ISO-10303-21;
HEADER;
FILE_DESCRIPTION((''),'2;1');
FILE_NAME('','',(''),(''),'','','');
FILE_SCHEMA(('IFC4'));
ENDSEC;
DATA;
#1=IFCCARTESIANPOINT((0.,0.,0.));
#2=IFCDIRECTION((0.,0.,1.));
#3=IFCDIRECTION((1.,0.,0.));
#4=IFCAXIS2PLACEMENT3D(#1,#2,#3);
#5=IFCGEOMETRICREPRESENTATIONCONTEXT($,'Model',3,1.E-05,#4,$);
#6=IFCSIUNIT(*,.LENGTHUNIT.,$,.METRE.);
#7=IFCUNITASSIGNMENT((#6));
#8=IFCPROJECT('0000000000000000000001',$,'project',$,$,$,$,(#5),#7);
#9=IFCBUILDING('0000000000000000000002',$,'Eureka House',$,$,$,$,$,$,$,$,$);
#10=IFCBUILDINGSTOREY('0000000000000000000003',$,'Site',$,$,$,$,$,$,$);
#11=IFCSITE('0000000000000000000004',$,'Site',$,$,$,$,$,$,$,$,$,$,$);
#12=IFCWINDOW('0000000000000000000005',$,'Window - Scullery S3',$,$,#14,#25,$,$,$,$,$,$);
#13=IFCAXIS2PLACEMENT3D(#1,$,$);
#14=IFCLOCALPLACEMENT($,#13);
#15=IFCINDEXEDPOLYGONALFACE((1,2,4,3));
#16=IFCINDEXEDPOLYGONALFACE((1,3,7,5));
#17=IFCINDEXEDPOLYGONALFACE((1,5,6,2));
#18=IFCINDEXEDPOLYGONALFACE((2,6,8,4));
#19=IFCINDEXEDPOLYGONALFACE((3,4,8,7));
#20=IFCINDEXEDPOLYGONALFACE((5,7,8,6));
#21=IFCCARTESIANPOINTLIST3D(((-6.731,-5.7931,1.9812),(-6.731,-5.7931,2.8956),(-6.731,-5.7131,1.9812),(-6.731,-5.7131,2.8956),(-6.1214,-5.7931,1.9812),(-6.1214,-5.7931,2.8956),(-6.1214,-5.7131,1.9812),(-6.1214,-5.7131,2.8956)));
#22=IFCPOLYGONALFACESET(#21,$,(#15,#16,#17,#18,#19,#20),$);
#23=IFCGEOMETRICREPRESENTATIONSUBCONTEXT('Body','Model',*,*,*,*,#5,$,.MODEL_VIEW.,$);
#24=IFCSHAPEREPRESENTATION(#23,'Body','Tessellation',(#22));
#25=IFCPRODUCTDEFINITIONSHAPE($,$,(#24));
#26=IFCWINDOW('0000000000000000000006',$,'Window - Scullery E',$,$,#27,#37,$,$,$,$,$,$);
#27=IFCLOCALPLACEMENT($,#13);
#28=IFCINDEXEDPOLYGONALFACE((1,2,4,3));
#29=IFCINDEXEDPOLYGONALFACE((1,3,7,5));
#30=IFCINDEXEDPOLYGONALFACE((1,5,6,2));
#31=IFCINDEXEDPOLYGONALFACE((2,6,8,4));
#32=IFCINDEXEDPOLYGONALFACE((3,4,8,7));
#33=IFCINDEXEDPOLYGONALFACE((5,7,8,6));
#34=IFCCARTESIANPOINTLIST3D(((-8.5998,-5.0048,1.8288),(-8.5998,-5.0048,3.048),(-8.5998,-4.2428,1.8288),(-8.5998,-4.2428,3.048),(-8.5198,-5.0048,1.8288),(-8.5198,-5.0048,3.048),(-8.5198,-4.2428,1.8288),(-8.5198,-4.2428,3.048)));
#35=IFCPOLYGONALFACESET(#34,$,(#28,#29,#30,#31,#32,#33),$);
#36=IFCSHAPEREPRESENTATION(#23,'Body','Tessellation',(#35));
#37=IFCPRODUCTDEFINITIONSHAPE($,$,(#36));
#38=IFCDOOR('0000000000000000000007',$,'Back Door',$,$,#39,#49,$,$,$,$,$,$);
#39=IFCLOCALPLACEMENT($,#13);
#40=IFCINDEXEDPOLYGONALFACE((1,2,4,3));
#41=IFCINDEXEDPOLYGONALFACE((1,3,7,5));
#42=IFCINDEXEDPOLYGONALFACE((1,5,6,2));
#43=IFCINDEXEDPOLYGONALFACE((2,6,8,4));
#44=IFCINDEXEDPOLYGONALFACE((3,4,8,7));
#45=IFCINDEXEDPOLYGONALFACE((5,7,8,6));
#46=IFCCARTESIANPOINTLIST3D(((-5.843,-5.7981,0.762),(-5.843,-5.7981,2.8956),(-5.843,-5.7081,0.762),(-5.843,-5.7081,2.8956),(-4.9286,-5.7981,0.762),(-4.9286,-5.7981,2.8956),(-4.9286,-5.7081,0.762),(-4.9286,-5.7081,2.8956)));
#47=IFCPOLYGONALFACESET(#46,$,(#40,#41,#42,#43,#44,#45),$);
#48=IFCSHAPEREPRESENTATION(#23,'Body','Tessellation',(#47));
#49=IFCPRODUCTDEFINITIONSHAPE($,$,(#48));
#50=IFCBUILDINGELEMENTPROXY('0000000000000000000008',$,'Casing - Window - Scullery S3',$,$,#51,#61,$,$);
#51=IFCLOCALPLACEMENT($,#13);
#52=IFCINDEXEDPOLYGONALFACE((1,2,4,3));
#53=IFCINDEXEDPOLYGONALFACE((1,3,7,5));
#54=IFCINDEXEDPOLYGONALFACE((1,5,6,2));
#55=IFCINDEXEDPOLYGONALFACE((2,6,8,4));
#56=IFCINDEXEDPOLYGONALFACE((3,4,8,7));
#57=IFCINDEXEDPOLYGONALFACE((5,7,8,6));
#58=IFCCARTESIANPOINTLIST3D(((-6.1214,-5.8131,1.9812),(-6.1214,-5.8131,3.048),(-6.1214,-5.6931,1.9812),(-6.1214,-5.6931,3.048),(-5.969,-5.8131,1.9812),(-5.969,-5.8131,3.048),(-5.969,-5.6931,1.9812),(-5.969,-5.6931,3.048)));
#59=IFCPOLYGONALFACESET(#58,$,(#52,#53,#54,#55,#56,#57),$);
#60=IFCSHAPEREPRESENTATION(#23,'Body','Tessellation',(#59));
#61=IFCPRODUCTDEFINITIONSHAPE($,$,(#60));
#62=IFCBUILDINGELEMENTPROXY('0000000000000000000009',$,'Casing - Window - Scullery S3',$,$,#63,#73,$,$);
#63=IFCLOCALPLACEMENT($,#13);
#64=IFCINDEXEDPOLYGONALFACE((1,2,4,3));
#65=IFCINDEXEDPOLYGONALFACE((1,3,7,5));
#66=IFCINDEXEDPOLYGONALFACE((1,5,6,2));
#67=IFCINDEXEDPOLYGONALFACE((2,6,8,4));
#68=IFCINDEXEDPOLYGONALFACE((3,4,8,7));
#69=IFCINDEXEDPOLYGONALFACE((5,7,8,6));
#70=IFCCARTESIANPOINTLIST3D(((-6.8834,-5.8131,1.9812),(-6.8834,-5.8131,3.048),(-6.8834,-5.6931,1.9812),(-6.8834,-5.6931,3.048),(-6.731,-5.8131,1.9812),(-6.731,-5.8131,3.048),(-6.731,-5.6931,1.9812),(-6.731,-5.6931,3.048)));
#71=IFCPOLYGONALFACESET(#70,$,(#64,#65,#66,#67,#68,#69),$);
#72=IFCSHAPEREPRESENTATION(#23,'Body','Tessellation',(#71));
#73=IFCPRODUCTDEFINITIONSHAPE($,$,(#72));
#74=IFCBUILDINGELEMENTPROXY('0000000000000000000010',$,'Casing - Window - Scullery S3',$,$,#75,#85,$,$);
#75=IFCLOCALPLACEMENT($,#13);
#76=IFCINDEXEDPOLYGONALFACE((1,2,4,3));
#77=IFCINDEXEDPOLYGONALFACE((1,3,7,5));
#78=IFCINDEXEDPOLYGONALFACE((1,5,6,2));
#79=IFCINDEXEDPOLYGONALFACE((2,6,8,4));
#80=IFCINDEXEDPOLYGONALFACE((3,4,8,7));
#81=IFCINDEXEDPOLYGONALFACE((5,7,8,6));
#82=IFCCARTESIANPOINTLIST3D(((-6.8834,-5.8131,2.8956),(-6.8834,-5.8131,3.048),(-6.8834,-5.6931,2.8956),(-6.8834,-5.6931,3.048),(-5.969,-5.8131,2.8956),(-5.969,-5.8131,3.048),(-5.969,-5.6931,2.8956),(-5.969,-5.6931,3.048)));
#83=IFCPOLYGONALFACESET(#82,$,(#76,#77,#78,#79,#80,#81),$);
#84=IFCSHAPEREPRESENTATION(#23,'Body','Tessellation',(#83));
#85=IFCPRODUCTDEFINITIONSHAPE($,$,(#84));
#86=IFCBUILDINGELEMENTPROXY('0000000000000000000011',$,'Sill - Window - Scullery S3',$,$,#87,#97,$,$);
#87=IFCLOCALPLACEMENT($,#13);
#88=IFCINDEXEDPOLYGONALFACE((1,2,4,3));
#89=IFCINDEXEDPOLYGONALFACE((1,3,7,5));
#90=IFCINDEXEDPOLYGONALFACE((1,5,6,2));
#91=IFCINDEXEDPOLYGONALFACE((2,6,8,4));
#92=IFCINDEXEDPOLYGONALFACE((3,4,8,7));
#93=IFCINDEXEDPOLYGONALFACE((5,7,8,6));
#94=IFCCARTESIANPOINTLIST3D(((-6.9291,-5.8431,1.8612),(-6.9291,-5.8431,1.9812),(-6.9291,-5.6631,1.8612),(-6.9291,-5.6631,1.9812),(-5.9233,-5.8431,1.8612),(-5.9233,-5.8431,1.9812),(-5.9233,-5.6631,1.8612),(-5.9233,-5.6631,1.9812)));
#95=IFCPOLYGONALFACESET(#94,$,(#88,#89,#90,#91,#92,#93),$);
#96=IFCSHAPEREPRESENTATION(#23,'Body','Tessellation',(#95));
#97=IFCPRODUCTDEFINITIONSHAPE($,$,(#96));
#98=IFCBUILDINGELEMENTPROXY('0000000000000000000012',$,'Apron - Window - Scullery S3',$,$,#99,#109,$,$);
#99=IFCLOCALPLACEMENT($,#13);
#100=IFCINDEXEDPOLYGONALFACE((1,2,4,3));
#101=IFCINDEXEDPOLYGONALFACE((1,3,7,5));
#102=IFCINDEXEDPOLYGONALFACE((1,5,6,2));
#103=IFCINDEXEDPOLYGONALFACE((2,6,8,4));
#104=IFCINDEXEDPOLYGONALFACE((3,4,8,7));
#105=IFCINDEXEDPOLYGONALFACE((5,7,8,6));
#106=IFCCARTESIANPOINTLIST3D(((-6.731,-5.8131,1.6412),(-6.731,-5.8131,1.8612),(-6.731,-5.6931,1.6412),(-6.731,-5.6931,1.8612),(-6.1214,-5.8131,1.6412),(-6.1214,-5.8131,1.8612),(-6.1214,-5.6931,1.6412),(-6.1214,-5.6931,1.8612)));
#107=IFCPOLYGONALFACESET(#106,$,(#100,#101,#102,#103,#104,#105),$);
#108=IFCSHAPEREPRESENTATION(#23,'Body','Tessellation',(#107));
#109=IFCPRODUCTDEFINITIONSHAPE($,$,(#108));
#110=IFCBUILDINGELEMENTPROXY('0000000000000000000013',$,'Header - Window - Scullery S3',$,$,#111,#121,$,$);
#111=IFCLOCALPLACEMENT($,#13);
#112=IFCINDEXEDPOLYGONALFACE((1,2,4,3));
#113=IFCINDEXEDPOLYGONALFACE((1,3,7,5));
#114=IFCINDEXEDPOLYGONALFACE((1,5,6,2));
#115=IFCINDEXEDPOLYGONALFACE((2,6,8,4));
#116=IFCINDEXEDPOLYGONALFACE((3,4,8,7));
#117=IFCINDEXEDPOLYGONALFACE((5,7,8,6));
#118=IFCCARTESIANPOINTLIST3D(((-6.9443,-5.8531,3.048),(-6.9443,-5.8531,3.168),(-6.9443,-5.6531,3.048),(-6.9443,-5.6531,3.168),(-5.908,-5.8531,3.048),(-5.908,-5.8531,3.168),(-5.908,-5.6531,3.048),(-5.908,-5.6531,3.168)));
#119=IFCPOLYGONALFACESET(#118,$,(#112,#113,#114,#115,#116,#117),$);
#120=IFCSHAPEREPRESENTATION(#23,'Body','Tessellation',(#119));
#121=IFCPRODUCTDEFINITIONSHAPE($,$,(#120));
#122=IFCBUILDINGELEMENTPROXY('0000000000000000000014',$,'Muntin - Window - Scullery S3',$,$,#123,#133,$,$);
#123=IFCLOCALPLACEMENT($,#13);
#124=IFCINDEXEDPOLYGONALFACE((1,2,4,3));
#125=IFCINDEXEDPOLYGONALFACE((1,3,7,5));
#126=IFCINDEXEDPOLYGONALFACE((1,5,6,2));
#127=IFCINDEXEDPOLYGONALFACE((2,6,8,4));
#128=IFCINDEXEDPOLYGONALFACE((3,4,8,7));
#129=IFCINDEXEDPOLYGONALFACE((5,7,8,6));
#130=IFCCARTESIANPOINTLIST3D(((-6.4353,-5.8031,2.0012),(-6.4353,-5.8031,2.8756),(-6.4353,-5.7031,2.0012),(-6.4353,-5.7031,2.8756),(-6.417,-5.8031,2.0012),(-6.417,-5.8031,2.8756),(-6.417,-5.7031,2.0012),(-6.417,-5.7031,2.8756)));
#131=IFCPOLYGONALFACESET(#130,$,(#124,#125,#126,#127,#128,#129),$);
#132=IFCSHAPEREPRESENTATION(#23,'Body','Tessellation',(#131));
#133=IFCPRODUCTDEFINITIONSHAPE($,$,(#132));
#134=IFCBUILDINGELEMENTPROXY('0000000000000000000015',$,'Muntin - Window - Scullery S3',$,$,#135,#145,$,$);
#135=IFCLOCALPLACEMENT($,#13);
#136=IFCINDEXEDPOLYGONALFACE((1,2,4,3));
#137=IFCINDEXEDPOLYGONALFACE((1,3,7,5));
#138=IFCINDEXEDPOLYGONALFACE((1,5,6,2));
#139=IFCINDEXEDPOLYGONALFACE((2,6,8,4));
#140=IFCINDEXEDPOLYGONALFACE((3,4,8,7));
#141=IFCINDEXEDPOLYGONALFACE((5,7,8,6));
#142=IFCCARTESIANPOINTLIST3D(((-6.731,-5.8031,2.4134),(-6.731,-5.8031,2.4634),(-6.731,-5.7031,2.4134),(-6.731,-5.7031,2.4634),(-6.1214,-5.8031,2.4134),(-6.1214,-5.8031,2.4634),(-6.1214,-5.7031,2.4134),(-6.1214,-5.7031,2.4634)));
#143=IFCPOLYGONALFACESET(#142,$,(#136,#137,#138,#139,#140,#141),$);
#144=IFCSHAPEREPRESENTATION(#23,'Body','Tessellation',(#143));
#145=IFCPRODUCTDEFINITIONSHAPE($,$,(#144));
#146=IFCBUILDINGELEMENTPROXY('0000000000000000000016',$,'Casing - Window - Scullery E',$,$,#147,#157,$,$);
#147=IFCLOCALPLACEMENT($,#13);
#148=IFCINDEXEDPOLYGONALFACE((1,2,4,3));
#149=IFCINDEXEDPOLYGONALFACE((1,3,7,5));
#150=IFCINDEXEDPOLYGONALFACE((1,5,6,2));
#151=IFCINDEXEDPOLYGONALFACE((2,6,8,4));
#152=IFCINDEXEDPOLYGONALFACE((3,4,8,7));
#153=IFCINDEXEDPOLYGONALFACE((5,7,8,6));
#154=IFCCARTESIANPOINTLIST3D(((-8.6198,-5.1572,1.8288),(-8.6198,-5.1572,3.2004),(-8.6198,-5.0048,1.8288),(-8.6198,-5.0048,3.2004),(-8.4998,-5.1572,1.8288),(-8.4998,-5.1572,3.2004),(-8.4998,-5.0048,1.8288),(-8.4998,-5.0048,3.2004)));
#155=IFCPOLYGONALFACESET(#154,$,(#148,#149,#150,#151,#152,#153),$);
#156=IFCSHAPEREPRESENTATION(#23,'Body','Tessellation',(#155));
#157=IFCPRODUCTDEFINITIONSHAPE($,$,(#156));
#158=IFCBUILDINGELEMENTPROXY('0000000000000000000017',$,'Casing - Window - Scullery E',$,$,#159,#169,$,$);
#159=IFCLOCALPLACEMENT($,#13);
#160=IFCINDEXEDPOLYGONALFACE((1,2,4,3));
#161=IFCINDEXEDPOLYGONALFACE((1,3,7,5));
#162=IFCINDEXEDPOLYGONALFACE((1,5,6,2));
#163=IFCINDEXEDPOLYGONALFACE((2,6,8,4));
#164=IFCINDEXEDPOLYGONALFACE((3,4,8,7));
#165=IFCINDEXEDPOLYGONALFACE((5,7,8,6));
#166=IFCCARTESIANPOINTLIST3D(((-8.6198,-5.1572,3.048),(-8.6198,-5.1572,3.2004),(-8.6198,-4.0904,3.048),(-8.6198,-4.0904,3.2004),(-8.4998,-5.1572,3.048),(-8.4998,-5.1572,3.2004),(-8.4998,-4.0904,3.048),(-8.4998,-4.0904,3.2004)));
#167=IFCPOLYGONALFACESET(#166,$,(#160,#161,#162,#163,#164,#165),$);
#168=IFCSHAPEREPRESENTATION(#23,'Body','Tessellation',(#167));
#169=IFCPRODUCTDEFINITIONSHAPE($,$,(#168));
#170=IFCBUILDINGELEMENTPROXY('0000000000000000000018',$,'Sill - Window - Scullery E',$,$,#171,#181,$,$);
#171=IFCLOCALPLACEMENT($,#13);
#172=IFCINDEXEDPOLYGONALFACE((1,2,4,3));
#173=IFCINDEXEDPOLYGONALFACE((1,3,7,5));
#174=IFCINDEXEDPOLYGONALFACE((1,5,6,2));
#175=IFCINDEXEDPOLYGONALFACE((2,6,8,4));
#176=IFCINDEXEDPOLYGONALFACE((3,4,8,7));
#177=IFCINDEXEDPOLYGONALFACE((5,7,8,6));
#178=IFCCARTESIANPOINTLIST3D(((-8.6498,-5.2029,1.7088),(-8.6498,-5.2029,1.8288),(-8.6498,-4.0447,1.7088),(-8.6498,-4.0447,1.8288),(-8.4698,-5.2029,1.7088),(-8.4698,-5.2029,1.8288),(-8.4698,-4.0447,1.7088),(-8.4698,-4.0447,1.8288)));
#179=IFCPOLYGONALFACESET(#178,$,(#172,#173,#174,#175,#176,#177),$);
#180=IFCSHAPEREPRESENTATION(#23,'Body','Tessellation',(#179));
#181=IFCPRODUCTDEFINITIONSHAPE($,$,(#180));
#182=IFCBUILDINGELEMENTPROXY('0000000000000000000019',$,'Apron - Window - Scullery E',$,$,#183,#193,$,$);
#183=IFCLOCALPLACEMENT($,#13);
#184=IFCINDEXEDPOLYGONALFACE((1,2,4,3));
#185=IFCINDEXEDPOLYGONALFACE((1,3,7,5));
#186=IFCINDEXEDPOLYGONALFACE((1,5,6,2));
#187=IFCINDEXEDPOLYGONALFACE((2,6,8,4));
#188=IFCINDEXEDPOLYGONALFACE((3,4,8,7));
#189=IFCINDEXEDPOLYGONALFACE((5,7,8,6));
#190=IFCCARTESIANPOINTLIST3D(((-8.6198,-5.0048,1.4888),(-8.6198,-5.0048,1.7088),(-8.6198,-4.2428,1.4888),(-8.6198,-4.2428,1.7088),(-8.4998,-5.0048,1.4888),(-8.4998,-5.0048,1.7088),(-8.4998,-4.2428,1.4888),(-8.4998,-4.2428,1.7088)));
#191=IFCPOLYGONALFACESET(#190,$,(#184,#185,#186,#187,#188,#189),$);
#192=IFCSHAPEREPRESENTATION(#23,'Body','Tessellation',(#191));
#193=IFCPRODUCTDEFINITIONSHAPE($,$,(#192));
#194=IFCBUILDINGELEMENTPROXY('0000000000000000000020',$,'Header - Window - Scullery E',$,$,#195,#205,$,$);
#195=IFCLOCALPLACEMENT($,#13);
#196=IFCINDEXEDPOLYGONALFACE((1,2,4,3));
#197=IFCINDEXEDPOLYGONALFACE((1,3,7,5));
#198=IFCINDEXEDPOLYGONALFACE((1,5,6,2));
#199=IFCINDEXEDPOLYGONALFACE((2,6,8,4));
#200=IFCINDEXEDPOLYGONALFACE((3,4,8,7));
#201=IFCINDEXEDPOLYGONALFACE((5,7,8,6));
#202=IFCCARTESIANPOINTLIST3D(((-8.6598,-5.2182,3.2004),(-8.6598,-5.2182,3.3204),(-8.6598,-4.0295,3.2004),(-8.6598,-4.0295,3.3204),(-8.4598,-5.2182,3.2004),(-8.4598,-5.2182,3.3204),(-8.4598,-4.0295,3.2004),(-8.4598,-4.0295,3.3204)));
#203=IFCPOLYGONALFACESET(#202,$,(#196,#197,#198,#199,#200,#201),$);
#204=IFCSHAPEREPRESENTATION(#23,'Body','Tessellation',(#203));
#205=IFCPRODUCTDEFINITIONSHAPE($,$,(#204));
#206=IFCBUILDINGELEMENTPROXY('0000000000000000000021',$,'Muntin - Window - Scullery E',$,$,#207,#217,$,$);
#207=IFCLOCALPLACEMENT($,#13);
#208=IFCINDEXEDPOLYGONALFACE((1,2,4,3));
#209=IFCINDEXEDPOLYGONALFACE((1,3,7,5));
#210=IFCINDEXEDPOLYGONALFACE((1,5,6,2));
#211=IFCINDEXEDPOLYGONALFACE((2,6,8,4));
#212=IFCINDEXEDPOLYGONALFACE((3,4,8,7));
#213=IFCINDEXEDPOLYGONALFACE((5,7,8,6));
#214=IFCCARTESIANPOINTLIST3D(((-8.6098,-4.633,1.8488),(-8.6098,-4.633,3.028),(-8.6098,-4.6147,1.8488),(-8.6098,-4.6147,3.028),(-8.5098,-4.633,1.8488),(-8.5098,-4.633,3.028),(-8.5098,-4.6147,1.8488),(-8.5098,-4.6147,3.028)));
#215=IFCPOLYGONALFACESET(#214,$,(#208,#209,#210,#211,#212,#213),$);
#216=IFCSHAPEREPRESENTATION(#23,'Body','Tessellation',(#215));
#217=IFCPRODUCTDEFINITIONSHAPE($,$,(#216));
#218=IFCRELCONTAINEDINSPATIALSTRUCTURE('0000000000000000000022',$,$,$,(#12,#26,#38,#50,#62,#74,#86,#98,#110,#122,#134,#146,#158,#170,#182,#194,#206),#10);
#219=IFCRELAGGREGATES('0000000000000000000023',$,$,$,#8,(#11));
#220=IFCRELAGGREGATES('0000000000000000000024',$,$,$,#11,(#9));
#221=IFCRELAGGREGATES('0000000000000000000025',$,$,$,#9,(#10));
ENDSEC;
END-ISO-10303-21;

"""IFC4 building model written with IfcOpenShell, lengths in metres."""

from ifc_helpers import new_model, si_unit, frame, origin, origin_with_axes, origin_2d, place, context, subcontext, project, spatial, rectangle, extrude, element, save


model = new_model("IFC4")

# Units and contexts
model_context = context("Model", 3, precision=1e-05, world=origin_with_axes())
body_context = subcontext(model_context, "Body", "Model", "MODEL_VIEW")
ifc_project = project(units=[si_unit("LENGTHUNIT", "METRE")], contexts=[model_context])

# Site, building, storey
site = spatial("IfcSite", under=ifc_project, Name="Site")
building = spatial("IfcBuilding", under=site, Name="Eureka House")
storey = spatial("IfcBuildingStorey", under=building, Name="Site")

# Windows
window_1_placement = place(None, frame((-6.4262, -5.7531, 1.9812), z_axis=(0.0, 0.0, 1.0), x_axis=(1.0, 0.0, 0.0)))
element("IfcWindow", 1, at=window_1_placement, inside=storey, Name="Window - Scullery S3", context=body_context, shape_type="SweptSolid", body=[
    extrude(rectangle(XDim=0.6096, YDim=0.08, at=origin_2d()), origin(), (0.0, 0.0, 1.0), 0.9144),
])
window_2_placement = place(None, frame((-8.5598, -4.6238, 1.8288), z_axis=(0.0, 0.0, 1.0), x_axis=(1.0, 0.0, 0.0)))
element("IfcWindow", 2, at=window_2_placement, inside=storey, Name="Window - Scullery E", context=body_context, shape_type="SweptSolid", body=[
    extrude(rectangle(XDim=0.08, YDim=0.762, at=origin_2d()), origin(), (0.0, 0.0, 1.0), 1.2192),
])

# Door
door_placement = place(None, frame((-5.3858, -5.7531, 0.762), z_axis=(0.0, 0.0, 1.0), x_axis=(1.0, 0.0, 0.0)))
element("IfcDoor", 3, at=door_placement, inside=storey, Name="Back Door", context=body_context, shape_type="SweptSolid", body=[
    extrude(rectangle(XDim=0.9144, YDim=0.09, at=origin_2d()), origin(), (0.0, 0.0, 1.0), 2.1336),
])

# Building element proxies
for number, where, z_axis, x_axis, name in (
    (4, (-6.0452, -5.7531, 1.9812), (0.0, 0.0, 1.0), (1.0, 0.0, 0.0), "Casing - Window - Scullery S3"),
    (5, (-6.8072, -5.7531, 1.9812), (0.0, 0.0, 1.0), (1.0, 0.0, 0.0), "Casing - Window - Scullery S3"),
):
    element("IfcBuildingElementProxy", number, at=place(None, frame(where, z_axis=z_axis, x_axis=x_axis)), inside=storey, Name=name, context=body_context, shape_type="SweptSolid", body=[
        extrude(rectangle(XDim=0.1524, YDim=0.12, at=origin_2d()), origin(), (0.0, 0.0, 1.0), 1.0668),
    ])
proxy_1_placement = place(None, frame((-6.4262, -5.7531, 2.8956), z_axis=(0.0, 0.0, 1.0), x_axis=(1.0, 0.0, 0.0)))
element("IfcBuildingElementProxy", 6, at=proxy_1_placement, inside=storey, Name="Casing - Window - Scullery S3", context=body_context, shape_type="SweptSolid", body=[
    extrude(rectangle(XDim=0.9144, YDim=0.12, at=origin_2d()), origin(), (0.0, 0.0, 1.0), 0.1524),
])
proxy_2_placement = place(None, frame((-6.4262, -5.7531, 1.8612), z_axis=(0.0, 0.0, 1.0), x_axis=(1.0, 0.0, 0.0)))
element("IfcBuildingElementProxy", 7, at=proxy_2_placement, inside=storey, Name="Sill - Window - Scullery S3", context=body_context, shape_type="SweptSolid", body=[
    extrude(rectangle(XDim=1.0058, YDim=0.18, at=origin_2d()), origin(), (0.0, 0.0, 1.0), 0.12),
])
proxy_3_placement = place(None, frame((-6.4262, -5.7531, 1.6412), z_axis=(0.0, 0.0, 1.0), x_axis=(1.0, 0.0, 0.0)))
element("IfcBuildingElementProxy", 8, at=proxy_3_placement, inside=storey, Name="Apron - Window - Scullery S3", context=body_context, shape_type="SweptSolid", body=[
    extrude(rectangle(XDim=0.6096, YDim=0.12, at=origin_2d()), origin(), (0.0, 0.0, 1.0), 0.22),
])
proxy_4_placement = place(None, frame((-6.4262, -5.7531, 3.048), z_axis=(0.0, 0.0, 1.0), x_axis=(1.0, 0.0, 0.0)))
element("IfcBuildingElementProxy", 9, at=proxy_4_placement, inside=storey, Name="Header - Window - Scullery S3", context=body_context, shape_type="SweptSolid", body=[
    extrude(rectangle(XDim=1.0363, YDim=0.2, at=origin_2d()), origin(), (0.0, 0.0, 1.0), 0.12),
])
proxy_5_placement = place(None, frame((-6.4262, -5.7531, 2.0012), z_axis=(0.0, 0.0, 1.0), x_axis=(1.0, 0.0, 0.0)))
element("IfcBuildingElementProxy", 10, at=proxy_5_placement, inside=storey, Name="Muntin - Window - Scullery S3", context=body_context, shape_type="SweptSolid", body=[
    extrude(rectangle(XDim=0.0183, YDim=0.1, at=origin_2d()), origin(), (0.0, 0.0, 1.0), 0.8744),
])
proxy_6_placement = place(None, frame((-6.4262, -5.7531, 2.4134), z_axis=(0.0, 0.0, 1.0), x_axis=(1.0, 0.0, 0.0)))
element("IfcBuildingElementProxy", 11, at=proxy_6_placement, inside=storey, Name="Muntin - Window - Scullery S3", context=body_context, shape_type="SweptSolid", body=[
    extrude(rectangle(XDim=0.6096, YDim=0.1, at=origin_2d()), origin(), (0.0, 0.0, 1.0), 0.05),
])
proxy_7_placement = place(None, frame((-8.5598, -5.081, 1.8288), z_axis=(0.0, 0.0, 1.0), x_axis=(1.0, 0.0, 0.0)))
element("IfcBuildingElementProxy", 12, at=proxy_7_placement, inside=storey, Name="Casing - Window - Scullery E", context=body_context, shape_type="SweptSolid", body=[
    extrude(rectangle(XDim=0.12, YDim=0.1524, at=origin_2d()), origin(), (0.0, 0.0, 1.0), 1.3716),
])
proxy_8_placement = place(None, frame((-8.5598, -4.6238, 3.048), z_axis=(0.0, 0.0, 1.0), x_axis=(1.0, 0.0, 0.0)))
element("IfcBuildingElementProxy", 13, at=proxy_8_placement, inside=storey, Name="Casing - Window - Scullery E", context=body_context, shape_type="SweptSolid", body=[
    extrude(rectangle(XDim=0.12, YDim=1.0668, at=origin_2d()), origin(), (0.0, 0.0, 1.0), 0.1524),
])
proxy_9_placement = place(None, frame((-8.5598, -4.6238, 1.7088), z_axis=(0.0, 0.0, 1.0), x_axis=(1.0, 0.0, 0.0)))
element("IfcBuildingElementProxy", 14, at=proxy_9_placement, inside=storey, Name="Sill - Window - Scullery E", context=body_context, shape_type="SweptSolid", body=[
    extrude(rectangle(XDim=0.18, YDim=1.1582, at=origin_2d()), origin(), (0.0, 0.0, 1.0), 0.12),
])
proxy_10_placement = place(None, frame((-8.5598, -4.6238, 1.4888), z_axis=(0.0, 0.0, 1.0), x_axis=(1.0, 0.0, 0.0)))
element("IfcBuildingElementProxy", 15, at=proxy_10_placement, inside=storey, Name="Apron - Window - Scullery E", context=body_context, shape_type="SweptSolid", body=[
    extrude(rectangle(XDim=0.12, YDim=0.762, at=origin_2d()), origin(), (0.0, 0.0, 1.0), 0.22),
])
proxy_11_placement = place(None, frame((-8.5598, -4.6238, 3.2004), z_axis=(0.0, 0.0, 1.0), x_axis=(1.0, 0.0, 0.0)))
element("IfcBuildingElementProxy", 16, at=proxy_11_placement, inside=storey, Name="Header - Window - Scullery E", context=body_context, shape_type="SweptSolid", body=[
    extrude(rectangle(XDim=0.2, YDim=1.1887, at=origin_2d()), origin(), (0.0, 0.0, 1.0), 0.12),
])
proxy_12_placement = place(None, frame((-8.5598, -4.6238, 1.8488), z_axis=(0.0, 0.0, 1.0), x_axis=(1.0, 0.0, 0.0)))
element("IfcBuildingElementProxy", 17, at=proxy_12_placement, inside=storey, Name="Muntin - Window - Scullery E", context=body_context, shape_type="SweptSolid", body=[
    extrude(rectangle(XDim=0.1, YDim=0.0183, at=origin_2d()), origin(), (0.0, 0.0, 1.0), 1.1792),
])

save(model, "model.ifc")
